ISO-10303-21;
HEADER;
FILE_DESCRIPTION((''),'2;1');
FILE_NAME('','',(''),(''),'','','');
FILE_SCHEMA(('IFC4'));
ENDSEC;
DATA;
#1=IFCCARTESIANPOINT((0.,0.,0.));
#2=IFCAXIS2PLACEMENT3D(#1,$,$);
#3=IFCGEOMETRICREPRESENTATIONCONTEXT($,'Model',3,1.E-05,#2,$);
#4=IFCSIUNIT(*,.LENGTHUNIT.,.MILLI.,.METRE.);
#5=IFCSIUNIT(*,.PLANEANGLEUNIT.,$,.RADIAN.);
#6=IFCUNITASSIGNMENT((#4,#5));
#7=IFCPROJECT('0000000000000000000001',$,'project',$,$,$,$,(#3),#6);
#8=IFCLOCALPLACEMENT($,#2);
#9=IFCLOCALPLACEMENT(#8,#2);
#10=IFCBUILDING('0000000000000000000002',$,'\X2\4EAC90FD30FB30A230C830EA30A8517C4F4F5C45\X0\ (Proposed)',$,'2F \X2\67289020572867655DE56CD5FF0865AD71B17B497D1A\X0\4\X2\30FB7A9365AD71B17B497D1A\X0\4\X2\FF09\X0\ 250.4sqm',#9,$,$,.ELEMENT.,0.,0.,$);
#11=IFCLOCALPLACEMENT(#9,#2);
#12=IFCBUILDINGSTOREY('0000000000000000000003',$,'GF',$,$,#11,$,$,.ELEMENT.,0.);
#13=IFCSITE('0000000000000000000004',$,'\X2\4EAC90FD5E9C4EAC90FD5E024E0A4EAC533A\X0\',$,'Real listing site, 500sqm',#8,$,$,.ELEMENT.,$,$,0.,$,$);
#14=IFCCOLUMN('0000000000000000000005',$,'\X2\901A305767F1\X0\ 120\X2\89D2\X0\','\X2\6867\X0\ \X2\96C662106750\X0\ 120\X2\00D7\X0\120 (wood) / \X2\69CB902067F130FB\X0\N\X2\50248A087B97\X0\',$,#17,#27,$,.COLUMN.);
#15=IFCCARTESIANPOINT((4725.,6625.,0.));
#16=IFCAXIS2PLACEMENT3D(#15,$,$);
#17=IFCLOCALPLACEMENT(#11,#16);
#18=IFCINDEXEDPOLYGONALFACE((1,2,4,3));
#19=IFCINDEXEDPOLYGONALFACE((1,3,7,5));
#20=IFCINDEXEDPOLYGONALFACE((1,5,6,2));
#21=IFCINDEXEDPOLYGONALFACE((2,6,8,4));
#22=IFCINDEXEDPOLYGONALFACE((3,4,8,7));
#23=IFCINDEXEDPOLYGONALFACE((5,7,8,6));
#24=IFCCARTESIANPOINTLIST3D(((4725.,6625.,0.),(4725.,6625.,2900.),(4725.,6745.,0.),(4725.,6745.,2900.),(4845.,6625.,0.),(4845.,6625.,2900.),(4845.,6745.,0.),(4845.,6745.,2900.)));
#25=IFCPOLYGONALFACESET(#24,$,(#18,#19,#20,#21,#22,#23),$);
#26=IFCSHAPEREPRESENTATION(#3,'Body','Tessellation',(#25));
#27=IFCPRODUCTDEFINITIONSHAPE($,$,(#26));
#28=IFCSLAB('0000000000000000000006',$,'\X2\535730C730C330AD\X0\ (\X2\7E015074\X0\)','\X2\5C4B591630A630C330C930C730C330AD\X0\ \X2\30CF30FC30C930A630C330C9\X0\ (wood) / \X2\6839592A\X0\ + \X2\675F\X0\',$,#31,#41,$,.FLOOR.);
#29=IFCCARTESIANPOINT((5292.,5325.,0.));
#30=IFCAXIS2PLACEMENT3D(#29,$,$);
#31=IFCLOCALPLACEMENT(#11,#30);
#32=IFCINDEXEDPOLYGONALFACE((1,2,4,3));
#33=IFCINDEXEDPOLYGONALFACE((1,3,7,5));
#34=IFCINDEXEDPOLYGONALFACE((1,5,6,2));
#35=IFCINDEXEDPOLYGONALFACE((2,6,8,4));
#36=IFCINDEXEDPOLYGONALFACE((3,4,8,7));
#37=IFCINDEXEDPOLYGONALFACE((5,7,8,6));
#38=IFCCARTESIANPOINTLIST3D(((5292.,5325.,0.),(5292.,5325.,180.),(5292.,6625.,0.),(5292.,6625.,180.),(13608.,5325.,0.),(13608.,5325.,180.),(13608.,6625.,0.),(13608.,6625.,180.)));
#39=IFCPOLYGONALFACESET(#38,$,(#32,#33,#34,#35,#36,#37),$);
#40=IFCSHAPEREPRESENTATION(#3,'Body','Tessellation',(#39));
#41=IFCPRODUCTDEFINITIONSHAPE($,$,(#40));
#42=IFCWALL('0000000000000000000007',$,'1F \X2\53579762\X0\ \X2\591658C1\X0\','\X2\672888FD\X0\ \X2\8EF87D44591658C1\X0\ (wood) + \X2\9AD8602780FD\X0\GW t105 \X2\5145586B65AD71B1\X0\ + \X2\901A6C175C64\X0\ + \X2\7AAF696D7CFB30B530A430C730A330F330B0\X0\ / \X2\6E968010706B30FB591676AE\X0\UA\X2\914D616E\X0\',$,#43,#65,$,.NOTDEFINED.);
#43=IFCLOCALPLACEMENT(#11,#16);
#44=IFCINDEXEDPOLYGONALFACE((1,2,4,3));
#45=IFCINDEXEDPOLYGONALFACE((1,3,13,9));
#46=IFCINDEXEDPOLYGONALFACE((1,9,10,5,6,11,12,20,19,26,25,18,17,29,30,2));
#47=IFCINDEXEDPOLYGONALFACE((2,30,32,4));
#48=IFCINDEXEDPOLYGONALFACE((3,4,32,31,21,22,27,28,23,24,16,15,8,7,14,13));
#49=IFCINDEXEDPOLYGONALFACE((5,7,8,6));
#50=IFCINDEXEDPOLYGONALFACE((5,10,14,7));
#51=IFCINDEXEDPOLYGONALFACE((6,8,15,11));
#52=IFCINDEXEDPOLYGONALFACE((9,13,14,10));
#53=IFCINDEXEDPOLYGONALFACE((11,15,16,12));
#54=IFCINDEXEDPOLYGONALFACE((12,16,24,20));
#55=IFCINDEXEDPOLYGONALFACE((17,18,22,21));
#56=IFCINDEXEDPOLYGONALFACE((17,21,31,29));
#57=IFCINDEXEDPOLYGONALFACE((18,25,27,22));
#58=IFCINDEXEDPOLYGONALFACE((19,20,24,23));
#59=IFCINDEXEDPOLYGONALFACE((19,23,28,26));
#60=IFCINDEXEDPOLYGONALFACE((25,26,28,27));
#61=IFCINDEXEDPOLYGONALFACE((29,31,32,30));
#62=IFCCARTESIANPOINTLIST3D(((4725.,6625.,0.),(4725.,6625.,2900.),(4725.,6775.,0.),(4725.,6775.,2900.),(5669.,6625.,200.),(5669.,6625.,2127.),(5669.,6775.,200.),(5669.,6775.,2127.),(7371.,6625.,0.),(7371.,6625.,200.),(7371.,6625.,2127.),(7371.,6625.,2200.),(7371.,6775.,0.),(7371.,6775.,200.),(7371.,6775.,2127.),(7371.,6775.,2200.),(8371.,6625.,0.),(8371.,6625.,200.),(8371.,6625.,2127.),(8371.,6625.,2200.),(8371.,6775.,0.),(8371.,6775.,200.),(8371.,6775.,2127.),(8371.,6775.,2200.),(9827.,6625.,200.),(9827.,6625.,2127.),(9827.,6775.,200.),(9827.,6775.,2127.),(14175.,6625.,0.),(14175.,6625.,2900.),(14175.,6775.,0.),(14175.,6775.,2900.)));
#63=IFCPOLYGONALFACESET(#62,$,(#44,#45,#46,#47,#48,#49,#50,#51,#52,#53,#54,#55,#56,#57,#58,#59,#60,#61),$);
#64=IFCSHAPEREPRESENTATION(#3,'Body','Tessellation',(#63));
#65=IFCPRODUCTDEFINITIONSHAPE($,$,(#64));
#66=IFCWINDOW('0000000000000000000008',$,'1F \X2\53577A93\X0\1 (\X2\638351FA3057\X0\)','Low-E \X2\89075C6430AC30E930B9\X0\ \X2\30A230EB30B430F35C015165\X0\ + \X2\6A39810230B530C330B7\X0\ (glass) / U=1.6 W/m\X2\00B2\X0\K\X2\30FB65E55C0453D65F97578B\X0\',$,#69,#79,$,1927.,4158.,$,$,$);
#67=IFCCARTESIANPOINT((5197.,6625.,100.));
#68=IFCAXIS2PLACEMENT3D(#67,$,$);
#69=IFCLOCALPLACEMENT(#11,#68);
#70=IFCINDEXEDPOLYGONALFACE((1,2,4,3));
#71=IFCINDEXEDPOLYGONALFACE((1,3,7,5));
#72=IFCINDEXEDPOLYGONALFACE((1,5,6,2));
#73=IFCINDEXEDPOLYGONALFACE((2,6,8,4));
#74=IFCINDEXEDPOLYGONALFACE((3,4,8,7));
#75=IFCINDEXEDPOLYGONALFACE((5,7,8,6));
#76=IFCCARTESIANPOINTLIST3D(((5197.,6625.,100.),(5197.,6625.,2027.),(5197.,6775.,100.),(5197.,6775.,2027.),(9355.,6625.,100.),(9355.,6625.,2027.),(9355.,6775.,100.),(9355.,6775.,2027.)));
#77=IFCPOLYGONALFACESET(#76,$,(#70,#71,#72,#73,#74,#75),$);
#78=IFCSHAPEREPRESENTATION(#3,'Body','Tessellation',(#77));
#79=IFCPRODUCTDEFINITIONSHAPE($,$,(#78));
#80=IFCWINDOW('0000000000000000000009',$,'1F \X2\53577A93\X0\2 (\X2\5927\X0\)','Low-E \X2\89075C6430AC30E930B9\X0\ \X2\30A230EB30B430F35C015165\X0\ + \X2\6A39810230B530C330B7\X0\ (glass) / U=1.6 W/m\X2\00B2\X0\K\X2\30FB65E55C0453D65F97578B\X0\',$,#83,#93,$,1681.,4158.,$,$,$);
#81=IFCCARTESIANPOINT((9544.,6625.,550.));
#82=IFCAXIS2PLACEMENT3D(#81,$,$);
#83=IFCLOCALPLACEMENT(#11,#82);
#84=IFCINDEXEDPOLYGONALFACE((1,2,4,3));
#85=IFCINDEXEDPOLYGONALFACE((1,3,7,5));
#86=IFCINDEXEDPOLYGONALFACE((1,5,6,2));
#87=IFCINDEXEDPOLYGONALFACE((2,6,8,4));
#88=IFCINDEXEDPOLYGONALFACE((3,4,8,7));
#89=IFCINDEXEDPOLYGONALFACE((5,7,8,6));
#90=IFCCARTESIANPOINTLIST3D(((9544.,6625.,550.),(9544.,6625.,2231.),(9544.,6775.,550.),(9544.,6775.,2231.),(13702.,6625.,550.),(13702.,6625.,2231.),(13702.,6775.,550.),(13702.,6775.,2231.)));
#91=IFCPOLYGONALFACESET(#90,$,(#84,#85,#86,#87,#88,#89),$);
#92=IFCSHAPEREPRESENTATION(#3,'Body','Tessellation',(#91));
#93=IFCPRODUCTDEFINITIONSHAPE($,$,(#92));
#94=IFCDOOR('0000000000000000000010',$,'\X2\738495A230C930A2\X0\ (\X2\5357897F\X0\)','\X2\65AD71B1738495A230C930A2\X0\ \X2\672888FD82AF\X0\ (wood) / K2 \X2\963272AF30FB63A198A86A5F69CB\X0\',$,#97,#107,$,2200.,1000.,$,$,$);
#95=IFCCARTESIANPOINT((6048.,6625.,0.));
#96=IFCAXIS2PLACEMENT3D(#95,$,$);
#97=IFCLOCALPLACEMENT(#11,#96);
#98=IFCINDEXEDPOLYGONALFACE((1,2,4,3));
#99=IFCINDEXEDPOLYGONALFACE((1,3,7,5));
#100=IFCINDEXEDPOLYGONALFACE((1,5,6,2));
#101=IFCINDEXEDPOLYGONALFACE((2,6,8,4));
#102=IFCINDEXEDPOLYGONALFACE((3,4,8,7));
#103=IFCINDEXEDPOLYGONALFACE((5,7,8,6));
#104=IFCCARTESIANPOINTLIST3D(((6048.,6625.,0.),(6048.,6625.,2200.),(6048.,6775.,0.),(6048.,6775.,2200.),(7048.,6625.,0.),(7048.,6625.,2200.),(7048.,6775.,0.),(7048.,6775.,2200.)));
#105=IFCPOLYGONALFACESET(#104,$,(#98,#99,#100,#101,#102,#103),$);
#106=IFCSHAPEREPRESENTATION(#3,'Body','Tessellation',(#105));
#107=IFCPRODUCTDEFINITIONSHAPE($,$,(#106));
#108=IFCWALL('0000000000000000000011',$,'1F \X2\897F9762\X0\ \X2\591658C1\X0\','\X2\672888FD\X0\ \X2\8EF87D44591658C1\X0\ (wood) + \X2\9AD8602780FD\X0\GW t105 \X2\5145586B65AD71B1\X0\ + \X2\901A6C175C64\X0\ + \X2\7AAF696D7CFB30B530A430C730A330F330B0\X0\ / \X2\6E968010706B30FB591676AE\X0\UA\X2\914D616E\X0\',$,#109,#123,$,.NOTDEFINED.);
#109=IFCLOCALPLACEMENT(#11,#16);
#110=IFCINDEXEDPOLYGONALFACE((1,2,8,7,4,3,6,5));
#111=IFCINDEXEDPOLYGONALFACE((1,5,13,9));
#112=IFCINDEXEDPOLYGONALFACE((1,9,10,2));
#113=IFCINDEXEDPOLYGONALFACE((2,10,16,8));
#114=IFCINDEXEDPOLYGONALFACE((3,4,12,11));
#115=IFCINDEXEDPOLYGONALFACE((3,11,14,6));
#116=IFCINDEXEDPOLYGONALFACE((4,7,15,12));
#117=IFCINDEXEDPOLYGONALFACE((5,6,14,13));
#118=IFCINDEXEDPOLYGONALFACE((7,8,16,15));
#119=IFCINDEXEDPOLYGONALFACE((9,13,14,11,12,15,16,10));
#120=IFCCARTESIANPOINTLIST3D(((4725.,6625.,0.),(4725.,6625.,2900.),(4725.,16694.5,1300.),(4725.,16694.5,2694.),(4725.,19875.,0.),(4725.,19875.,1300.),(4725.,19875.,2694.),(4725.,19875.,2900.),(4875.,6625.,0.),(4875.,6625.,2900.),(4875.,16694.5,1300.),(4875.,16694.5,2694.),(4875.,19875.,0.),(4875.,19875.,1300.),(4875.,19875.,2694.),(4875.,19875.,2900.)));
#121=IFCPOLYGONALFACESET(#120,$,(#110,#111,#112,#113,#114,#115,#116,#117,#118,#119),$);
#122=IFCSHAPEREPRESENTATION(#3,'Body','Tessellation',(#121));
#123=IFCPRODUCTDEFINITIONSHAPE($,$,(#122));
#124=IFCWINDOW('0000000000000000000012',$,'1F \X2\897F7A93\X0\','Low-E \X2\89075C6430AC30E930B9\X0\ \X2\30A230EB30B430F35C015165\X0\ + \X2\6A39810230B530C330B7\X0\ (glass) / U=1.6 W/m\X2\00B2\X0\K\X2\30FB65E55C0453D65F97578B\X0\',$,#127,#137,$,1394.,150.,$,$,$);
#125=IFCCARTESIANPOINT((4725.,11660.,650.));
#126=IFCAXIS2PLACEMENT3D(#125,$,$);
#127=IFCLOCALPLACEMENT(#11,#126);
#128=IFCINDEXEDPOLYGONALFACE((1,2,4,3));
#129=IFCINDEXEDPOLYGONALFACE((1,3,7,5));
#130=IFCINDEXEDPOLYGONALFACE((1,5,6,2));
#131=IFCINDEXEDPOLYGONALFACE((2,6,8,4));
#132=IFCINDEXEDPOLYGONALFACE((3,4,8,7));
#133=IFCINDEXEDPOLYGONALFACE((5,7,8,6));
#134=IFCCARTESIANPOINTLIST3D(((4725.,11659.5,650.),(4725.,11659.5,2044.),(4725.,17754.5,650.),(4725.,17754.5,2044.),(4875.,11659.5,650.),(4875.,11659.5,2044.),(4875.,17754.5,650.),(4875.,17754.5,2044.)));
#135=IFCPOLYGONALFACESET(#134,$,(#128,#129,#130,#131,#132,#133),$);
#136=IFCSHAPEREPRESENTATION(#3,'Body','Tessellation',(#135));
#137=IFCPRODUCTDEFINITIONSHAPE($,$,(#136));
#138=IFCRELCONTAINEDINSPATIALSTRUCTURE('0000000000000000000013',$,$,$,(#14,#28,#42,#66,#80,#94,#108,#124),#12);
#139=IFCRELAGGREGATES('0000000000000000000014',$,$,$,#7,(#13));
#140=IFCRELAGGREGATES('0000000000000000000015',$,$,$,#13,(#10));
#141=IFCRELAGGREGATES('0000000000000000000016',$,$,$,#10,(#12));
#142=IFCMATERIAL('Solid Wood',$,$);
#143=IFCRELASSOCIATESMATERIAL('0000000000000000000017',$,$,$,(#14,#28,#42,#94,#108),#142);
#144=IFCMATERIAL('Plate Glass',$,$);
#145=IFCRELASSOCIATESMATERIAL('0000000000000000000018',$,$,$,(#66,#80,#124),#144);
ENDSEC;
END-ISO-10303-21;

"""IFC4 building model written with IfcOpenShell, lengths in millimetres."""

from ifc_helpers import new_model, si_unit, frame, frame_2d, origin, place, context, project, spatial, rectangle, extrude, material, element, fill, save


model = new_model("IFC4")

# Units and contexts
model_context = context("Model", 3, precision=1e-05, world=origin())
ifc_project = project(units=[si_unit("LENGTHUNIT", "METRE", prefix="MILLI"), si_unit("PLANEANGLEUNIT", "RADIAN")], contexts=[model_context])

# Site, building, storey
site_placement = place(None, origin())
site = spatial("IfcSite", under=ifc_project, at=site_placement, Name="京都府京都市上京区", ObjectType="Real listing site, 500sqm", CompositionType="ELEMENT", RefElevation=0.0)
building_placement = place(site_placement, origin())
building = spatial("IfcBuilding", under=site, at=building_placement, Name="京都・アトリエ兼住居 (Proposed)", ObjectType="2F 木造在来工法（断熱等級4・窓断熱等級4） 250.4sqm", CompositionType="ELEMENT", ElevationOfRefHeight=0.0, ElevationOfTerrain=0.0)
storey_placement = place(building_placement, origin())
storey = spatial("IfcBuildingStorey", under=building, at=storey_placement, Name="GF", CompositionType="ELEMENT", Elevation=0.0)

# Column
ifc_material_1 = material(Name="Solid Wood")
column_placement = place(storey_placement, frame((4725.0, 6625.0, 0.0)))
element("IfcColumn", 1, at=column_placement, inside=storey, material=ifc_material_1, Name="通し柱 120角", Description="桧 集成材 120×120 (wood) / 構造柱・N値計算", PredefinedType="COLUMN", context=model_context, shape_type="SweptSolid", body=[
    extrude(rectangle(XDim=120.0, YDim=120.0, at=frame_2d((60.0, 60.0))), frame((4725.0, 6625.0, 0.0)), (0.0, 0.0, 1.0), 2900.0),
])

# Slab
slab_1_placement = place(storey_placement, frame((5292.0, 5325.0, 0.0)))
element("IfcSlab", 2, at=slab_1_placement, inside=storey, material=ifc_material_1, Name="南デッキ (縁側)", Description="屋外ウッドデッキ ハードウッド (wood) / 根太 + 束", PredefinedType="FLOOR", context=model_context, shape_type="SweptSolid", body=[
    extrude(rectangle(XDim=8316.0, YDim=1300.0, at=frame_2d((4158.0, 650.0))), frame((5292.0, 5325.0, 0.0)), (0.0, 0.0, 1.0), 180.0),
])

# Wall, openings, windows, door
wall_1_placement = place(storey_placement, frame((4725.0, 6625.0, 0.0)))
wall_1 = element("IfcWall", 3, at=wall_1_placement, inside=storey, material=ifc_material_1, Name="1F 南面 外壁", Description="木製 軸組外壁 (wood) + 高性能GW t105 充填断熱 + 通気層 + 窯業系サイディング / 準耐火・外皮UA配慮", PredefinedType="NOTDEFINED", context=model_context, shape_type="SweptSolid", body=[
    extrude(rectangle(XDim=9450.0, YDim=150.0, at=frame_2d((4725.0, 75.0))), frame((4725.0, 6625.0, 0.0)), (0.0, 0.0, 1.0), 2900.0),
])
opening_1_placement = place(storey_placement, frame((5197.0, 6625.0, 100.0)))
opening_1 = element("IfcOpeningElement", 4, at=opening_1_placement, cuts=wall_1, PredefinedType="NOTDEFINED", context=model_context, shape_type="SweptSolid", body=[
    extrude(rectangle(XDim=4158.0, YDim=150.0, at=frame_2d((2079.0, 75.0))), frame((5197.0, 6625.0, 100.0)), (0.0, 0.0, 1.0), 1927.0),
])
opening_2_placement = place(storey_placement, frame((9544.0, 6625.0, 550.0)))
opening_2 = element("IfcOpeningElement", 5, at=opening_2_placement, cuts=wall_1, PredefinedType="NOTDEFINED", context=model_context, shape_type="SweptSolid", body=[
    extrude(rectangle(XDim=4158.0, YDim=150.0, at=frame_2d((2079.0, 75.0))), frame((9544.0, 6625.0, 550.0)), (0.0, 0.0, 1.0), 1681.0),
])
opening_3_placement = place(storey_placement, frame((6048.0, 6625.0, 0.0)))
opening_3 = element("IfcOpeningElement", 6, at=opening_3_placement, cuts=wall_1, PredefinedType="NOTDEFINED", context=model_context, shape_type="SweptSolid", body=[
    extrude(rectangle(XDim=1000.0, YDim=150.0, at=frame_2d((500.0, 75.0))), frame((6048.0, 6625.0, 0.0)), (0.0, 0.0, 1.0), 2200.0),
])
ifc_material_2 = material(Name="Plate Glass")
window_1_placement = place(storey_placement, frame((5197.0, 6625.0, 100.0)))
window_1 = element("IfcWindow", 7, at=window_1_placement, inside=storey, material=ifc_material_2, Name="1F 南窓1 (掃出し)", Description="Low-E 複層ガラス アルゴン封入 + 樹脂サッシ (glass) / U=1.6 W/m²K・日射取得型", OverallHeight=1927.0, OverallWidth=4158.0, context=model_context, shape_type="SweptSolid", body=[
    extrude(rectangle(XDim=4158.0, YDim=150.0, at=frame_2d((2079.0, 75.0))), frame((5197.0, 6625.0, 100.0)), (0.0, 0.0, 1.0), 1927.0),
])
fill(opening_1, window_1)
window_2_placement = place(storey_placement, frame((9544.0, 6625.0, 550.0)))
window_2 = element("IfcWindow", 8, at=window_2_placement, inside=storey, material=ifc_material_2, Name="1F 南窓2 (大)", Description="Low-E 複層ガラス アルゴン封入 + 樹脂サッシ (glass) / U=1.6 W/m²K・日射取得型", OverallHeight=1681.0, OverallWidth=4158.0, context=model_context, shape_type="SweptSolid", body=[
    extrude(rectangle(XDim=4158.0, YDim=150.0, at=frame_2d((2079.0, 75.0))), frame((9544.0, 6625.0, 550.0)), (0.0, 0.0, 1.0), 1681.0),
])
fill(opening_2, window_2)
door_placement = place(storey_placement, frame((6048.0, 6625.0, 0.0)))
door = element("IfcDoor", 9, at=door_placement, inside=storey, material=ifc_material_1, Name="玄関ドア (南西)", Description="断熱玄関ドア 木製芯 (wood) / K2 防犯・採風機構", OverallHeight=2200.0, OverallWidth=1000.0, context=model_context, shape_type="SweptSolid", body=[
    extrude(rectangle(XDim=1000.0, YDim=150.0, at=frame_2d((500.0, 75.0))), frame((6048.0, 6625.0, 0.0)), (0.0, 0.0, 1.0), 2200.0),
])
fill(opening_3, door)

# Wall, opening, window
wall_2_placement = place(storey_placement, frame((4725.0, 6625.0, 0.0)))
wall_2 = element("IfcWall", 10, at=wall_2_placement, inside=storey, material=ifc_material_1, Name="1F 西面 外壁", Description="木製 軸組外壁 (wood) + 高性能GW t105 充填断熱 + 通気層 + 窯業系サイディング / 準耐火・外皮UA配慮", PredefinedType="NOTDEFINED", context=model_context, shape_type="SweptSolid", body=[
    extrude(rectangle(XDim=150.0, YDim=13250.0, at=frame_2d((75.0, 6625.0))), frame((4725.0, 6625.0, 0.0)), (0.0, 0.0, 1.0), 2900.0),
])
opening_4_placement = place(storey_placement, frame((4725.0, 11660.0, 650.0)))
opening_4 = element("IfcOpeningElement", 11, at=opening_4_placement, cuts=wall_2, PredefinedType="NOTDEFINED", context=model_context, shape_type="SweptSolid", body=[
    extrude(rectangle(XDim=150.0, YDim=6095.0, at=frame_2d((75.0, 3047.0))), frame((4725.0, 11660.0, 650.0)), (0.0, 0.0, 1.0), 1394.0),
])
window_3_placement = place(storey_placement, frame((4725.0, 11660.0, 650.0)))
window_3 = element("IfcWindow", 12, at=window_3_placement, inside=storey, material=ifc_material_2, Name="1F 西窓", Description="Low-E 複層ガラス アルゴン封入 + 樹脂サッシ (glass) / U=1.6 W/m²K・日射取得型", OverallHeight=1394.0, OverallWidth=150.0, context=model_context, shape_type="SweptSolid", body=[
    extrude(rectangle(XDim=150.0, YDim=6095.0, at=frame_2d((75.0, 3047.0))), frame((4725.0, 11660.0, 650.0)), (0.0, 0.0, 1.0), 1394.0),
])
fill(opening_4, window_3)

save(model, "model.ifc")
